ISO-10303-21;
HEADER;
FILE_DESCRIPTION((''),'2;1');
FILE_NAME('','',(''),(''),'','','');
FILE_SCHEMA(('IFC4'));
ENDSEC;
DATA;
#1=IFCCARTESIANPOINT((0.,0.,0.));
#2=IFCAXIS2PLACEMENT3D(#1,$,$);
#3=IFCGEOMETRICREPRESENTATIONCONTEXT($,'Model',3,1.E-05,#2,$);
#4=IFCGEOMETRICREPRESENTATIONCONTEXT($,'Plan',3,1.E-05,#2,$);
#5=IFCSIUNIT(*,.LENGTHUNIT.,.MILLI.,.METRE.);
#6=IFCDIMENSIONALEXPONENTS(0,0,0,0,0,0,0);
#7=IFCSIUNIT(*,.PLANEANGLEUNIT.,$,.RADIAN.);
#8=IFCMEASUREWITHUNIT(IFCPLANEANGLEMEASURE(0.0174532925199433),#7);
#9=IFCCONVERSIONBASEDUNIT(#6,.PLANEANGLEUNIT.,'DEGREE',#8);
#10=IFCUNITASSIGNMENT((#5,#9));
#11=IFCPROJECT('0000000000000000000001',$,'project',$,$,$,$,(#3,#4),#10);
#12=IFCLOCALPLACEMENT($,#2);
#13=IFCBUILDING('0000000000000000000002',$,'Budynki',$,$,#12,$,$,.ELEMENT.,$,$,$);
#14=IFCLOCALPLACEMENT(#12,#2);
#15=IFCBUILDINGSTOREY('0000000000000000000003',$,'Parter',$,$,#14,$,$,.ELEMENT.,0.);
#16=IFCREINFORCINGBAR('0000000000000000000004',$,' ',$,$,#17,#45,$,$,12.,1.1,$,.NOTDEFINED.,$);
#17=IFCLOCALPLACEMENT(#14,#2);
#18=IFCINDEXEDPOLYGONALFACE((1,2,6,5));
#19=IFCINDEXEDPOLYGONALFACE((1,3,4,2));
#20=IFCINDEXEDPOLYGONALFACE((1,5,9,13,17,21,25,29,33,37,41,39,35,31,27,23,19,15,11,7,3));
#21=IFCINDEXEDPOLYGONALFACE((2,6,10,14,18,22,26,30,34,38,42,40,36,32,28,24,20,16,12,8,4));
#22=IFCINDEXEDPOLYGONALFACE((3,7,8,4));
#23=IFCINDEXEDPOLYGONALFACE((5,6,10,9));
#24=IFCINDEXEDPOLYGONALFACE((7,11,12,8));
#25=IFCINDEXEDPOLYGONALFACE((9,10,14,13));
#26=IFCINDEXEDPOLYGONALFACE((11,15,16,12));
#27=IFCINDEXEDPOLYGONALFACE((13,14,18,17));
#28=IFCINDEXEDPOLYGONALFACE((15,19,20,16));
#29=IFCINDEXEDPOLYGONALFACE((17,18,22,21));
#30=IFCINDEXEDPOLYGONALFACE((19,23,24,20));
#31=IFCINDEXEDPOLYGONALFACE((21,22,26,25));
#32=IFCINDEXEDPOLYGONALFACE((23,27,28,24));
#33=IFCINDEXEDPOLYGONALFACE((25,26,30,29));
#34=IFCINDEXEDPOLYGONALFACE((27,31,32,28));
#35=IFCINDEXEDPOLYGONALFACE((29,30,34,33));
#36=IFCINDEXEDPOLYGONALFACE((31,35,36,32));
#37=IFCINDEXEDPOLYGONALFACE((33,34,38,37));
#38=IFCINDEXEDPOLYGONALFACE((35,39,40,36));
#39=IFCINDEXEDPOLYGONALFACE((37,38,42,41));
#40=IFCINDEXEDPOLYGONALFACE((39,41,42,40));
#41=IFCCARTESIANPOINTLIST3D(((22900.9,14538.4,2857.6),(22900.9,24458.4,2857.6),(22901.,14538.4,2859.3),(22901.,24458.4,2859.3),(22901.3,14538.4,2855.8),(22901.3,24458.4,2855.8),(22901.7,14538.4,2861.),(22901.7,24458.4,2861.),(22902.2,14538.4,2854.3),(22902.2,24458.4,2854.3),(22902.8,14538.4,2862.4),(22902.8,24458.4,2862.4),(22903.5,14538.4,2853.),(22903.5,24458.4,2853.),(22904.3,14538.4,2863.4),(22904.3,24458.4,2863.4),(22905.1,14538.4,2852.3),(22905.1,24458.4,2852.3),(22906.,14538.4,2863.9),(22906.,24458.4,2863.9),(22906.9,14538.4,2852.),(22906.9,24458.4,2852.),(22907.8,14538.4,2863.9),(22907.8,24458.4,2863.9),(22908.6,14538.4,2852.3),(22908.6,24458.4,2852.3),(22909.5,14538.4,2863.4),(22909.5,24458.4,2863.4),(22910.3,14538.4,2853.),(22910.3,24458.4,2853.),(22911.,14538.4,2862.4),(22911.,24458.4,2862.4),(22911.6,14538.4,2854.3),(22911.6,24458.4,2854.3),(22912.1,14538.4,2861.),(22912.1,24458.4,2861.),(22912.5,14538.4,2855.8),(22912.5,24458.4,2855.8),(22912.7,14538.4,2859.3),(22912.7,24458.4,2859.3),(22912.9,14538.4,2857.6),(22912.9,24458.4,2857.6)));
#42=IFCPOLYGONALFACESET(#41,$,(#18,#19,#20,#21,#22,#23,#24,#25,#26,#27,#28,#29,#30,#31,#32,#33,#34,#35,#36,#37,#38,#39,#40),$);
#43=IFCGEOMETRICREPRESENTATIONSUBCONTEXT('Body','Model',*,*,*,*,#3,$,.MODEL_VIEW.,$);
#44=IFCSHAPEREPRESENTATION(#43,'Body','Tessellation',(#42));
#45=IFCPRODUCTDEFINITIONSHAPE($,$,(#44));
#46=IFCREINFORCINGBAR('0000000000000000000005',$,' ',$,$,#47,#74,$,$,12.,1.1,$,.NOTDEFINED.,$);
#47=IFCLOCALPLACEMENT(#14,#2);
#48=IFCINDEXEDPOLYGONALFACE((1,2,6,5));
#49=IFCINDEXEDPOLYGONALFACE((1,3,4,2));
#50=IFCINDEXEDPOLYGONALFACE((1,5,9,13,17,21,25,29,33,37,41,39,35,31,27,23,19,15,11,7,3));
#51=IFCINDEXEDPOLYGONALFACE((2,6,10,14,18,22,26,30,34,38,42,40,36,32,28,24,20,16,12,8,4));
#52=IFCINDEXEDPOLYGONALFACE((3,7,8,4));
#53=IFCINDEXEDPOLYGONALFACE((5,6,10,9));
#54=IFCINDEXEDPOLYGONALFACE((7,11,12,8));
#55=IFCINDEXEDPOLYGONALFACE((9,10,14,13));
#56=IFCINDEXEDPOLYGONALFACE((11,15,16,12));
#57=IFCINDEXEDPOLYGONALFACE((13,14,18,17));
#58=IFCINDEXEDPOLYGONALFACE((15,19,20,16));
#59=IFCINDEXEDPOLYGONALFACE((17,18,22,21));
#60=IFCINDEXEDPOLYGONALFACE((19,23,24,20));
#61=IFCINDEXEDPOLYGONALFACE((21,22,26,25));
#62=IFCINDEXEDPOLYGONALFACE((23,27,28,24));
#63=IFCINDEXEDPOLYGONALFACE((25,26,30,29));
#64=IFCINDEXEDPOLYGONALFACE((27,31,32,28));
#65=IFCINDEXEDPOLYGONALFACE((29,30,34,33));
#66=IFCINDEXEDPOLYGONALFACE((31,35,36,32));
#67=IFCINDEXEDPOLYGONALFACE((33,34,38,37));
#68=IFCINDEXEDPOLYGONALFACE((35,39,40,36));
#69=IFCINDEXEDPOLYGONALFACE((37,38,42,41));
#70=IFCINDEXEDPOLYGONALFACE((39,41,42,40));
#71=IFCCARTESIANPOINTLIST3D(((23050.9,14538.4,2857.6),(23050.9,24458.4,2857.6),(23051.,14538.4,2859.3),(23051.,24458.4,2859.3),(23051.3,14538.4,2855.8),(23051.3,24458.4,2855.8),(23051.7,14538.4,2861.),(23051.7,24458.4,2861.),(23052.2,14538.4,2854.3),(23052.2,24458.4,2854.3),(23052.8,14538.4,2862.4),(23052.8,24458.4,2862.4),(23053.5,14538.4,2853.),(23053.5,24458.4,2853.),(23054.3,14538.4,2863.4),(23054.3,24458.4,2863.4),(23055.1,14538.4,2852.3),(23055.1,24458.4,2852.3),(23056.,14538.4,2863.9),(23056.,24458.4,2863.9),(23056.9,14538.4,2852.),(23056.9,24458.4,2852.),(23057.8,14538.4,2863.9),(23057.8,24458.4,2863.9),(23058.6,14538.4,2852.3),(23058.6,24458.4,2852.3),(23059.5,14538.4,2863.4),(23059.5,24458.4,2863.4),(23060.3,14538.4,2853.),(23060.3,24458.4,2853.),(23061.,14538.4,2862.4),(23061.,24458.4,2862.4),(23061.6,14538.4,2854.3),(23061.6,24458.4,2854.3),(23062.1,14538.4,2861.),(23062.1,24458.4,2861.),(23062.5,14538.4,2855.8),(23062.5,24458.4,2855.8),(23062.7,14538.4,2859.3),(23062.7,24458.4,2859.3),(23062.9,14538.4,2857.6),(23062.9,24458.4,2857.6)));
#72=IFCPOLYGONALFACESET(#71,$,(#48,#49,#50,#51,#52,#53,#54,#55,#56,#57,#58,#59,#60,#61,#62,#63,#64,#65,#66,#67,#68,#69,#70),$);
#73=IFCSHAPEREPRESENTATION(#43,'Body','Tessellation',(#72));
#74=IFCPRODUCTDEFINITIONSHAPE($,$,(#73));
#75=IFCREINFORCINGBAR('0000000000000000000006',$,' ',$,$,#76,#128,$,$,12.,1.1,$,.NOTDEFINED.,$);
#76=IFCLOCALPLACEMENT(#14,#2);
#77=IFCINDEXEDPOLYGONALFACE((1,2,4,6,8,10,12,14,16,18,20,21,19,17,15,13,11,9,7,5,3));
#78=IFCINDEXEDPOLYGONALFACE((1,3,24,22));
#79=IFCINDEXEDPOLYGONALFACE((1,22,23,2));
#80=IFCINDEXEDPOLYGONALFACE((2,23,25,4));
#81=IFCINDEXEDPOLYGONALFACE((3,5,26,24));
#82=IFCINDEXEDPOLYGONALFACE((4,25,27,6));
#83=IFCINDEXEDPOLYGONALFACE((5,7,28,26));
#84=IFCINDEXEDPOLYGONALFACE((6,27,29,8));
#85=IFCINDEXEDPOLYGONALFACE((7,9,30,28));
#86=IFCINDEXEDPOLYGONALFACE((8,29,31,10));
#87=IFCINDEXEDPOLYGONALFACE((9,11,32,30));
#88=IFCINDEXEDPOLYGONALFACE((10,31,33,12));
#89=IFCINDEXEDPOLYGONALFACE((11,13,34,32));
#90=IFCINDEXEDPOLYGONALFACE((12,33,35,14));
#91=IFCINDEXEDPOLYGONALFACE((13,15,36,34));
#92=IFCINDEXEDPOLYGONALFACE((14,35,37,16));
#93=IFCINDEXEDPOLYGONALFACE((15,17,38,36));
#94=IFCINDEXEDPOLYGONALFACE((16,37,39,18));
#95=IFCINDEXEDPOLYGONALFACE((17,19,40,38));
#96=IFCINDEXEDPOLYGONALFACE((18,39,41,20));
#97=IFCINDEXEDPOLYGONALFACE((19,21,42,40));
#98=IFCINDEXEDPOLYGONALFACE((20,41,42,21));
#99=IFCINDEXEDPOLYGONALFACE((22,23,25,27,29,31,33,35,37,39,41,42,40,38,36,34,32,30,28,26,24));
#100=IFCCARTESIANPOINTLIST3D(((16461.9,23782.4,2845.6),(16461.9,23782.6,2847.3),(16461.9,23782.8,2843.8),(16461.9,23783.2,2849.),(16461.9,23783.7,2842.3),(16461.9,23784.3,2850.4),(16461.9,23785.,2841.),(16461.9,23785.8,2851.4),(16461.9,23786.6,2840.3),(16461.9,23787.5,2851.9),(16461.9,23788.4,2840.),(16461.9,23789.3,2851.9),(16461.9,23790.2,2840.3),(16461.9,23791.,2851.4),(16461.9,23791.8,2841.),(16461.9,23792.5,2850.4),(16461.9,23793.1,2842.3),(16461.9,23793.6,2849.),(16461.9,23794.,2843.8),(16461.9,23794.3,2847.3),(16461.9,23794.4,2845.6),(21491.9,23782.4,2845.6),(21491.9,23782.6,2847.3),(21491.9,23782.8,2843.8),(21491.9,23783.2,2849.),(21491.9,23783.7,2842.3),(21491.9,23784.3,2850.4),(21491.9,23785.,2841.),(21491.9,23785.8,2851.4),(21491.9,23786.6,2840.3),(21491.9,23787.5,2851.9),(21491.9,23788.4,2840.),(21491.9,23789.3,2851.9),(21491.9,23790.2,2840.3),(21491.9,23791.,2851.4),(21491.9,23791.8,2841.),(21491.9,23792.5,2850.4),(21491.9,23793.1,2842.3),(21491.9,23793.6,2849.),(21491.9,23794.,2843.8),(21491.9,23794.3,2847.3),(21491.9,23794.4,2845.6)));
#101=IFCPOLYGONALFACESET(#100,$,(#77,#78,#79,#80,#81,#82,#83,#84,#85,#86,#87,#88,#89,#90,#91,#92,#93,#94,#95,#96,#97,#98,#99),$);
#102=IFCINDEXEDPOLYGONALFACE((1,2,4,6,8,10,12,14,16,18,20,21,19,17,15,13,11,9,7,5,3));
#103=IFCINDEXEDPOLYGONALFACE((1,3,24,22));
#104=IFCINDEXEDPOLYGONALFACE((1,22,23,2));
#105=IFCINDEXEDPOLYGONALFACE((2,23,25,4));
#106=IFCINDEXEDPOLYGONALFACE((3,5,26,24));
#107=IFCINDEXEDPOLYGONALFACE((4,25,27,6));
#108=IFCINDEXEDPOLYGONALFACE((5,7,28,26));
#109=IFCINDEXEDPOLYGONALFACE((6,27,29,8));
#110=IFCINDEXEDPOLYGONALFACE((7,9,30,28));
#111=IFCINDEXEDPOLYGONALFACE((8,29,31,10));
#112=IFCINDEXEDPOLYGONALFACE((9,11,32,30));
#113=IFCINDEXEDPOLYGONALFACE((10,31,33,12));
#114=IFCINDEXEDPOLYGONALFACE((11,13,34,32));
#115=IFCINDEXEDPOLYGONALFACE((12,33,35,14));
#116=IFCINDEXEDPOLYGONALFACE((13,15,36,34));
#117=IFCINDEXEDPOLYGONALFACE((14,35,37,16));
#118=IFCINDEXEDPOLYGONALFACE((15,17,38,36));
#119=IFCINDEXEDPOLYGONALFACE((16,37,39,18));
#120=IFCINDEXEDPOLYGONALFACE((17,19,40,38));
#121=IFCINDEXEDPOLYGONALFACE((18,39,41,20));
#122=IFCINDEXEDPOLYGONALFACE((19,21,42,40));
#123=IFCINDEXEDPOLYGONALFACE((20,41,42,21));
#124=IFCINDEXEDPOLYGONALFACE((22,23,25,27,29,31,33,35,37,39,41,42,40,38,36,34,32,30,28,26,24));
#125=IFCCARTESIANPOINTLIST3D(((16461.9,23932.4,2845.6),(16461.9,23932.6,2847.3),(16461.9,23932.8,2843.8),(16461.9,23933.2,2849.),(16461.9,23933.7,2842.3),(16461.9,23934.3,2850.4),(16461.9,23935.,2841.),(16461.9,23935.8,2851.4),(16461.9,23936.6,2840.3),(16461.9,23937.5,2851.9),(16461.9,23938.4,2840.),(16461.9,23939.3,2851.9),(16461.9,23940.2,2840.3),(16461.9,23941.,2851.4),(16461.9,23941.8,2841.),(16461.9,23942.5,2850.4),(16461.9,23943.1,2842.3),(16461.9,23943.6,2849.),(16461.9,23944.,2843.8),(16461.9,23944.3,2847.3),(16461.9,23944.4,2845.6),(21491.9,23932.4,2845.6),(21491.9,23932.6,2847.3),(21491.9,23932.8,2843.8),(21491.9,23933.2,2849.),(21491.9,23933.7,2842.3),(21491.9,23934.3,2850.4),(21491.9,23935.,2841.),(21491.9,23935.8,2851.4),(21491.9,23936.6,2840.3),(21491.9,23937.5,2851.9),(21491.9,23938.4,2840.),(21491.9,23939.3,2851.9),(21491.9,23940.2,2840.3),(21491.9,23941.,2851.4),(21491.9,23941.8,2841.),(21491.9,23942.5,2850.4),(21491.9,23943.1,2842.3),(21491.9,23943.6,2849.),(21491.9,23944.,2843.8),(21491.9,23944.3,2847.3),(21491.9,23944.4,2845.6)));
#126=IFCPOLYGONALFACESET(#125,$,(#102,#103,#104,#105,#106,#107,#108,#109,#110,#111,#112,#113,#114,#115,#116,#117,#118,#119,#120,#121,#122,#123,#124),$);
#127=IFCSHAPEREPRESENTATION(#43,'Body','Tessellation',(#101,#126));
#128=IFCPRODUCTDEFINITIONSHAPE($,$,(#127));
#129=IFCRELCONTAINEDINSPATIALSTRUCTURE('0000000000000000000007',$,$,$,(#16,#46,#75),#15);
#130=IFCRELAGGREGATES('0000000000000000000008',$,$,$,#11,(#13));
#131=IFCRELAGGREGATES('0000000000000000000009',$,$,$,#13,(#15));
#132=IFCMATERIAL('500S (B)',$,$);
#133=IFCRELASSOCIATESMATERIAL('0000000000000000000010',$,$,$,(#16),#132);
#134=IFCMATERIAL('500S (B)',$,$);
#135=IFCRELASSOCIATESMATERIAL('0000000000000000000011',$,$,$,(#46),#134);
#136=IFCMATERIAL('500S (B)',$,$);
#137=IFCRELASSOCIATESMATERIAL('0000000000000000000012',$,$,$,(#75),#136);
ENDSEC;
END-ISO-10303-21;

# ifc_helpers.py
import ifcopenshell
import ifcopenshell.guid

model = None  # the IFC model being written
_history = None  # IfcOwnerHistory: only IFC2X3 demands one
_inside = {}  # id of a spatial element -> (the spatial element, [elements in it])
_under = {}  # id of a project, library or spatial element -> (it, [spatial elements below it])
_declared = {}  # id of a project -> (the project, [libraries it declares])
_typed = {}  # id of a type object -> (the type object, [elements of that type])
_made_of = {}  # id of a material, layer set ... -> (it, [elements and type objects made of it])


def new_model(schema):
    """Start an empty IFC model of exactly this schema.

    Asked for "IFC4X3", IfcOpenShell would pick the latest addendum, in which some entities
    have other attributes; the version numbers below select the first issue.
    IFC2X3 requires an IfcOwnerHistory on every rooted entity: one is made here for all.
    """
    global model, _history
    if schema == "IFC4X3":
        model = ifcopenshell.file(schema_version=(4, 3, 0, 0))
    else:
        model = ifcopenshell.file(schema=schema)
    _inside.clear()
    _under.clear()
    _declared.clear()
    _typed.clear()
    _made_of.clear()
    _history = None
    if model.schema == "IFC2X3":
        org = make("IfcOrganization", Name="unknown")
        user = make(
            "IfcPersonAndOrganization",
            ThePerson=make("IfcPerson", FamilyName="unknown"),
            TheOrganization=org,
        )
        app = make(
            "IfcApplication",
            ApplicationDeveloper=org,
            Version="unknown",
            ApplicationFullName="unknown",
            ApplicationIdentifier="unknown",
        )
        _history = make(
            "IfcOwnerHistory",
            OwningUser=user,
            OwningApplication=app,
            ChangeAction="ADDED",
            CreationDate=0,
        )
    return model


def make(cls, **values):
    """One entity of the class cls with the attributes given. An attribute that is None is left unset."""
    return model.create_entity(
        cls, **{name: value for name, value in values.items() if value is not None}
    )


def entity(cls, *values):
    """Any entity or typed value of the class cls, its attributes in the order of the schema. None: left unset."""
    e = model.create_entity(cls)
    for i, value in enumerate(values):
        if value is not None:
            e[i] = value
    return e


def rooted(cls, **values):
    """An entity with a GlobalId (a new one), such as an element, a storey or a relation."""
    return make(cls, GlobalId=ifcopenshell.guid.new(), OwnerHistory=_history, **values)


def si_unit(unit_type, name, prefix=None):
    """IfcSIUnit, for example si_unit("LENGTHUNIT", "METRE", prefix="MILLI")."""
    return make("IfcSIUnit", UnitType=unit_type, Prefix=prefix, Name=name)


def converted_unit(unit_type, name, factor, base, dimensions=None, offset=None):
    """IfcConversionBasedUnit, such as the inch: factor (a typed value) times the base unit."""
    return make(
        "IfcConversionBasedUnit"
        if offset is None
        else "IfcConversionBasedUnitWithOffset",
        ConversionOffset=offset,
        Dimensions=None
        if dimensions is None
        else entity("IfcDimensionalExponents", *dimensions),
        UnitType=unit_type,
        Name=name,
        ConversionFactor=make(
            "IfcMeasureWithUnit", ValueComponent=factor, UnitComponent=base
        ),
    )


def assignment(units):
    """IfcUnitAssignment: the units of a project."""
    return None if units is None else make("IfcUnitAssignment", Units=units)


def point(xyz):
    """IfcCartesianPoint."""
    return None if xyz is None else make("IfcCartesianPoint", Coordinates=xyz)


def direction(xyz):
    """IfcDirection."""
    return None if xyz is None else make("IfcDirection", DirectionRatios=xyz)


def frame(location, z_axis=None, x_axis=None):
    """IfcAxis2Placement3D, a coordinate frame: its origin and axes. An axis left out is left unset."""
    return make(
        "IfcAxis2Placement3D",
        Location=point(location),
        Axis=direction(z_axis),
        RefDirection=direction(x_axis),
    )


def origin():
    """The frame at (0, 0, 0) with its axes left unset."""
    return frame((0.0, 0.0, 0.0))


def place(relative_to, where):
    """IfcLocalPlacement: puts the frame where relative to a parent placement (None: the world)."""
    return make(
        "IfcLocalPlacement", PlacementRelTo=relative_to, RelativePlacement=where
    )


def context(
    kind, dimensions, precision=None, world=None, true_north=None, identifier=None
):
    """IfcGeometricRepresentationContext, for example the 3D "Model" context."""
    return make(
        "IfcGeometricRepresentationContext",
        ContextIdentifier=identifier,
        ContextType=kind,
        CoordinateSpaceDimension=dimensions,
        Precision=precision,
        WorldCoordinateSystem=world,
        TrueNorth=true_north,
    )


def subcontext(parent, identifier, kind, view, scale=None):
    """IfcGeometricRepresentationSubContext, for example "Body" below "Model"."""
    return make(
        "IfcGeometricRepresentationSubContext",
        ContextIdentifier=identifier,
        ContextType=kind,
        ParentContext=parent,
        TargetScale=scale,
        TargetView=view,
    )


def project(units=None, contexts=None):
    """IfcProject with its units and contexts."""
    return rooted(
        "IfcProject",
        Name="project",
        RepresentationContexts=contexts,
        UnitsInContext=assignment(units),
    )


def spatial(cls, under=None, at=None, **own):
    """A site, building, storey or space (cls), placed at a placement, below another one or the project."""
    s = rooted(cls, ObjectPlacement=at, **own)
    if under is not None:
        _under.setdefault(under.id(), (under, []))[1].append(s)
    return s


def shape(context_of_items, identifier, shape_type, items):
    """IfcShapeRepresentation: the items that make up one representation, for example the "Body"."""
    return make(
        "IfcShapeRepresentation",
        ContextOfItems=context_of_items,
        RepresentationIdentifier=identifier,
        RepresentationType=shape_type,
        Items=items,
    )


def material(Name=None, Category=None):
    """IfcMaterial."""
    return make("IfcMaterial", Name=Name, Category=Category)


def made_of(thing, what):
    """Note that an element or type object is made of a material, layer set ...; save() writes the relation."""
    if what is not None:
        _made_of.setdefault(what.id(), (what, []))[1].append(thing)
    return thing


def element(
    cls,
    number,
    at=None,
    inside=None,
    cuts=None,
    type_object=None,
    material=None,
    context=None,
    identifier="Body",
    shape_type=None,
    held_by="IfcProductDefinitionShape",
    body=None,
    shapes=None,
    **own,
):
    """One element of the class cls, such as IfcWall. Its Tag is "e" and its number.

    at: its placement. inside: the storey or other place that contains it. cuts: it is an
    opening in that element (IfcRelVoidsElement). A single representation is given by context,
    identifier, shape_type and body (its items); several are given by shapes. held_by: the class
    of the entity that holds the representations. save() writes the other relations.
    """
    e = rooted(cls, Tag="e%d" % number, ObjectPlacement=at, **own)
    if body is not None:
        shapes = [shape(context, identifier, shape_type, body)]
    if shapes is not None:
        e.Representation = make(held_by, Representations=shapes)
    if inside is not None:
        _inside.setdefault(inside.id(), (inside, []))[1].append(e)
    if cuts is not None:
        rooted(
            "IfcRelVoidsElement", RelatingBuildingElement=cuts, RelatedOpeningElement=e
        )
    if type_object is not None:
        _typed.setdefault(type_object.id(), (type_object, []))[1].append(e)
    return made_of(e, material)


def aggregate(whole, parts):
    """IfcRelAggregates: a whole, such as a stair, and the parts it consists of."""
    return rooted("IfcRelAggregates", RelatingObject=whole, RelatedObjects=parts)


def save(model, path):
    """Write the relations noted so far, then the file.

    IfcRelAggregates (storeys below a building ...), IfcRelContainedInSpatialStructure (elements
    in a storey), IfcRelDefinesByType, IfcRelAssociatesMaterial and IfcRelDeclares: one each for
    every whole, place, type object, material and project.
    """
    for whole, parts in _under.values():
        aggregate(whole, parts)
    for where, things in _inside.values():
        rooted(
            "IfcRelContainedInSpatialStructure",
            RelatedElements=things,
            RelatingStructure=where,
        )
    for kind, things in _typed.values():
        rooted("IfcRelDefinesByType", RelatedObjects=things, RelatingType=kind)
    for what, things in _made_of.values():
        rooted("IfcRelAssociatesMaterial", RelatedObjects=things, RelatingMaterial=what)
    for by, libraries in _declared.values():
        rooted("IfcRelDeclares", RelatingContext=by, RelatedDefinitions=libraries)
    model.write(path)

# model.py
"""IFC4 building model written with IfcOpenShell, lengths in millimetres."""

from ifc_helpers import new_model, entity, si_unit, converted_unit, frame, origin, place, context, subcontext, project, spatial, material, element, save


model = new_model("IFC4")

# Units and contexts
model_context = context("Model", 3, precision=1e-05, world=origin())
plan_context = context("Plan", 3, precision=1e-05, world=origin())
body_context = subcontext(model_context, "Body", "Model", "MODEL_VIEW")
ifc_project = project(units=[si_unit("LENGTHUNIT", "METRE", prefix="MILLI"), converted_unit("PLANEANGLEUNIT", "DEGREE", entity("IfcPlaneAngleMeasure", 0.0174532925199433), si_unit("PLANEANGLEUNIT", "RADIAN"), dimensions=[0, 0, 0, 0, 0, 0, 0])], contexts=[model_context, plan_context])

# Building, storey
building_placement = place(None, origin())
building = spatial("IfcBuilding", under=ifc_project, at=building_placement, Name="Budynki", CompositionType="ELEMENT")
storey_placement = place(building_placement, origin())
storey = spatial("IfcBuildingStorey", under=building, at=storey_placement, Name="Parter", CompositionType="ELEMENT", Elevation=0.0)

# Reinforcing bars
ifc_material_1 = material(Name="500S (B)")
reinforcing_bar_1_placement = place(storey_placement, frame((22906.9, 24458.4, 2858.0)))
element("IfcReinforcingBar", 1, at=reinforcing_bar_1_placement, inside=storey, material=ifc_material_1, Name=" ", CrossSectionArea=1.1, NominalDiameter=12.0, PredefinedType="NOTDEFINED", context=body_context, shape_type="AdvancedSweptSolid", body=[
    entity("IfcSweptDiskSolid", entity("IfcPolyline", [entity("IfcCartesianPoint", [0.0, 0.0, 0.0]), entity("IfcCartesianPoint", [0.0, -9920.0, 0.0])]), 6.0, None, 0.0, 1.0),
])
ifc_material_2 = material(Name="500S (B)")
reinforcing_bar_2_placement = place(storey_placement, frame((23056.9, 24458.4, 2858.0)))
element("IfcReinforcingBar", 2, at=reinforcing_bar_2_placement, inside=storey, material=ifc_material_2, Name=" ", CrossSectionArea=1.1, NominalDiameter=12.0, PredefinedType="NOTDEFINED", context=body_context, shape_type="AdvancedSweptSolid", body=[
    entity("IfcSweptDiskSolid", entity("IfcPolyline", [entity("IfcCartesianPoint", [0.0, 0.0, 0.0]), entity("IfcCartesianPoint", [0.0, -9920.0, 0.0])]), 6.0, None, 0.0, 1.0),
])
ifc_material_3 = material(Name="500S (B)")
reinforcing_bar_3_placement = place(storey_placement, frame((21491.9, 23788.4, 2846.0)))
element("IfcReinforcingBar", 3, at=reinforcing_bar_3_placement, inside=storey, material=ifc_material_3, Name=" ", CrossSectionArea=1.1, NominalDiameter=12.0, PredefinedType="NOTDEFINED", context=body_context, shape_type="AdvancedSweptSolid", body=[
    entity("IfcSweptDiskSolid", entity("IfcPolyline", [entity("IfcCartesianPoint", [0.0, 0.0, 0.0]), entity("IfcCartesianPoint", [-5030.0, 0.0, 0.0])]), 6.0, None, 0.0, 1.0),
    entity("IfcSweptDiskSolid", entity("IfcPolyline", [entity("IfcCartesianPoint", [0.0, 150.0, 0.0]), entity("IfcCartesianPoint", [-5030.0, 150.0, 0.0])]), 6.0, None, 0.0, 1.0),
])

save(model, "model.ifc")
